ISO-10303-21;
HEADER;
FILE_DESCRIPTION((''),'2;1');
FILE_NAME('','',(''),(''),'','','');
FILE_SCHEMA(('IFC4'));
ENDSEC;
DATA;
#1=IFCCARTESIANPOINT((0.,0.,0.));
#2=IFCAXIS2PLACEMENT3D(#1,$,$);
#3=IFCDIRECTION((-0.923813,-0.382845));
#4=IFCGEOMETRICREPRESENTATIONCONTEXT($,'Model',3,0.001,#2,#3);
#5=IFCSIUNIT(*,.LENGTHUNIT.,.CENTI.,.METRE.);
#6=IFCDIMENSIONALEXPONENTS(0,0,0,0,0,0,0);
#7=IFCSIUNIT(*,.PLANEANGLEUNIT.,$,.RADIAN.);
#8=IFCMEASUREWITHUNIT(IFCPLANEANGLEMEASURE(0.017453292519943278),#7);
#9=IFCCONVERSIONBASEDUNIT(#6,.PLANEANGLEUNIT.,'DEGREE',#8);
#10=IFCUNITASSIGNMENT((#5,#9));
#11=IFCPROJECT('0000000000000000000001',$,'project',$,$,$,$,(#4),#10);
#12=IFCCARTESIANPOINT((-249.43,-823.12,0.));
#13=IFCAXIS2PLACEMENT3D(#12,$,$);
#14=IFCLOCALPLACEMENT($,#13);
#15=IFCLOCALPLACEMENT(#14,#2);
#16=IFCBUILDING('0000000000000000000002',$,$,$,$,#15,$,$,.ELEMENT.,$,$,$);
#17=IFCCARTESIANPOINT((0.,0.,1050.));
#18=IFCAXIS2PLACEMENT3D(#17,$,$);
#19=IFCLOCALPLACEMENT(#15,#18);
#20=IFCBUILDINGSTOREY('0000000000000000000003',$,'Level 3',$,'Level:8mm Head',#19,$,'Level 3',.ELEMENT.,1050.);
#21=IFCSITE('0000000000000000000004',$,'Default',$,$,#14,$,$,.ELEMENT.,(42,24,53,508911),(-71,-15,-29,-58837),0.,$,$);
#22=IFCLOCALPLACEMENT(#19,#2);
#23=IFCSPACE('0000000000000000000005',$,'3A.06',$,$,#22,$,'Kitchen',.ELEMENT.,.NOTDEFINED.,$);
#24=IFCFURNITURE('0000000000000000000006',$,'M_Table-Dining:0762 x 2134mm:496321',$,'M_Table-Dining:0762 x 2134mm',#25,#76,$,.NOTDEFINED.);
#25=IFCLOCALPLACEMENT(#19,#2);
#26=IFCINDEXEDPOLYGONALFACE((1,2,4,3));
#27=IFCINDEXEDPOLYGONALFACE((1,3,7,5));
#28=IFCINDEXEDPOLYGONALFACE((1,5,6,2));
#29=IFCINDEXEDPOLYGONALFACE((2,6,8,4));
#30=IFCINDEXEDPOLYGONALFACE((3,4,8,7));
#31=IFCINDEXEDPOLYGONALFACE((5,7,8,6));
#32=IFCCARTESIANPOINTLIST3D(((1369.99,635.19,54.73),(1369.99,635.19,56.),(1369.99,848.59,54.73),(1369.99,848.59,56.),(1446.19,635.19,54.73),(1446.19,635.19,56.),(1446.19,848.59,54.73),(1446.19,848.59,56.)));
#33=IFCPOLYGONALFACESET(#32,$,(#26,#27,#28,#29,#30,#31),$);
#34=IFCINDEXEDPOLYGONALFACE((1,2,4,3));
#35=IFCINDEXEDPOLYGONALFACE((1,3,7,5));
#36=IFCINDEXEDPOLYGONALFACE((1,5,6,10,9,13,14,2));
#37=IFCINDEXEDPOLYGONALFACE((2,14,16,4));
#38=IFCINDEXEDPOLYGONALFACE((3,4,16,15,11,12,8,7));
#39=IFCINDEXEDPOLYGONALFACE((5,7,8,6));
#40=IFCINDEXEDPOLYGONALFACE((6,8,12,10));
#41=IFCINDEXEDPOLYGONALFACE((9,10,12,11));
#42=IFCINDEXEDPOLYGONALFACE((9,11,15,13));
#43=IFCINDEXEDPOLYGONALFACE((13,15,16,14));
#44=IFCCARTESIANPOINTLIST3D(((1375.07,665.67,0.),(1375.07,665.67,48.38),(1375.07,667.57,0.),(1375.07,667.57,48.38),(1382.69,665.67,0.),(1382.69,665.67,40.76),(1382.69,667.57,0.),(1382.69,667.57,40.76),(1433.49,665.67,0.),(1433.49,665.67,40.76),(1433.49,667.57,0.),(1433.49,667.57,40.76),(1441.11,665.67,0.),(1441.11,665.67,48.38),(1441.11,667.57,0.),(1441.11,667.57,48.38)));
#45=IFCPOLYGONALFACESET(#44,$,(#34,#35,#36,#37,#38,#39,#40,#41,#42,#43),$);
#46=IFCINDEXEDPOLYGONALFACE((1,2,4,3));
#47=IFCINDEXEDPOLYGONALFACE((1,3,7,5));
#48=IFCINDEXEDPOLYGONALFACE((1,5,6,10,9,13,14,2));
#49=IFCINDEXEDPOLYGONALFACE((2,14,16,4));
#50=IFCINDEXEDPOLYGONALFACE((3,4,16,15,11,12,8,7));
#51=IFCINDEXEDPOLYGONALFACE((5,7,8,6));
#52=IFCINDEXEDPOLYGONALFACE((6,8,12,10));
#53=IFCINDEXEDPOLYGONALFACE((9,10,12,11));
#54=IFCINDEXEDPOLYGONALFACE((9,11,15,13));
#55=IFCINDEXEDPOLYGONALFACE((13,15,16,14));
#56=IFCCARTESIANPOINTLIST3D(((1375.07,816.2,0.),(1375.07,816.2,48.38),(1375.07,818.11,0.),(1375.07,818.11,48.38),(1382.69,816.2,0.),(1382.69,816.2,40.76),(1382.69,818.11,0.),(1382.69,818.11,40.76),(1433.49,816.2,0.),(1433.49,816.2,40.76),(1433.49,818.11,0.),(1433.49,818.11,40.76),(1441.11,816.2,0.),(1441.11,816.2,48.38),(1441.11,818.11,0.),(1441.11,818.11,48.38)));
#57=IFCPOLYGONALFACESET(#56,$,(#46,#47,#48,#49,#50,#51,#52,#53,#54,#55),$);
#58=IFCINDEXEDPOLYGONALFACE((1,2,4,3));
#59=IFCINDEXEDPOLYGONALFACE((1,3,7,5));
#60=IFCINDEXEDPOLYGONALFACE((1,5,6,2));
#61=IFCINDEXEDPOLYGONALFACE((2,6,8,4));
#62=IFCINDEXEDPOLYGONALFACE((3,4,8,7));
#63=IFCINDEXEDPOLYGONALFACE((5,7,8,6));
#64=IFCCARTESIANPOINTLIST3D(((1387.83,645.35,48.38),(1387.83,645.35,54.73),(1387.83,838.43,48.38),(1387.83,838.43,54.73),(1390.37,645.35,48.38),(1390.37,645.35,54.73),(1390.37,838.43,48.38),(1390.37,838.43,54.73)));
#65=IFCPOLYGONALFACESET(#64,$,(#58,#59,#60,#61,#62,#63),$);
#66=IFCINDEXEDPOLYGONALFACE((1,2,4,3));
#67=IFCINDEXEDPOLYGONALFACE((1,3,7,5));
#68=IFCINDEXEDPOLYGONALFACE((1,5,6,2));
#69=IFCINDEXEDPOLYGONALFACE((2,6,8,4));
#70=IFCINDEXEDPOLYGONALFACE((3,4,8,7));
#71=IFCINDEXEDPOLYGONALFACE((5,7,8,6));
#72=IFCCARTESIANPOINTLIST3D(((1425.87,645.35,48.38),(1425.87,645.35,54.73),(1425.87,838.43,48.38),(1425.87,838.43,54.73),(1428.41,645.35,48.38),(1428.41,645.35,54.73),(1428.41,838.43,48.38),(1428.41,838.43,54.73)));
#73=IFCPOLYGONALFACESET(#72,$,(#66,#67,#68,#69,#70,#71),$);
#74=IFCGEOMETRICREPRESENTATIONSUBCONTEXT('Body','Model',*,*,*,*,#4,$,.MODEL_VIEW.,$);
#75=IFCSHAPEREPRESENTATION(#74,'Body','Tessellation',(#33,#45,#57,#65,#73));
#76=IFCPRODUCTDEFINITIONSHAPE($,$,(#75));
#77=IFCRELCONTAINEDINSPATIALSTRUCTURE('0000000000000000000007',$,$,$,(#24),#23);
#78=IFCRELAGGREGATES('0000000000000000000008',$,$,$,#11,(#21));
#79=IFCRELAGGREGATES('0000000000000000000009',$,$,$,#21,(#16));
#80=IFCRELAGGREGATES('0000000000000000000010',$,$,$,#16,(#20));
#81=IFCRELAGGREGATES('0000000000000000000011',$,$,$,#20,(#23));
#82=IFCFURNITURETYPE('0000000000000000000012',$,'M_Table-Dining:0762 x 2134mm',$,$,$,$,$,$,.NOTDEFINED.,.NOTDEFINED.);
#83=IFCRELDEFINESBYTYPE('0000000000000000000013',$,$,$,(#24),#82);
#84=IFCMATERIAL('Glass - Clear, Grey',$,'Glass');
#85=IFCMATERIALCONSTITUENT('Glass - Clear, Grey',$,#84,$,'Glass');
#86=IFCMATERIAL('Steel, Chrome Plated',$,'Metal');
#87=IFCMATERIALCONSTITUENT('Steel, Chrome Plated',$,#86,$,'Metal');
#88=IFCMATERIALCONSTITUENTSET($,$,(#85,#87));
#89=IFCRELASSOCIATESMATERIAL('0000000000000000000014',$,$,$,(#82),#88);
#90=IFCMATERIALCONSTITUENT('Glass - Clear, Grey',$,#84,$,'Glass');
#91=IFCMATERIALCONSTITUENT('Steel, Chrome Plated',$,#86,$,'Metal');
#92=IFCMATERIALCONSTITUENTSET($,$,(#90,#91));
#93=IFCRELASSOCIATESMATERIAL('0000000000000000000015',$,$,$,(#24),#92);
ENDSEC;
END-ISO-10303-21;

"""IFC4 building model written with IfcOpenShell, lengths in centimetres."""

from ifc_helpers import new_model, entity, si_unit, converted_unit, direction, frame, origin, place, context, subcontext, project, spatial, indexed_curve, outline, extrude, source, transform, mapped, material, constituent, constituent_set, type_object, type_shapes, element, save


model = new_model("IFC4")

# Units and contexts
model_context = context("Model", 3, precision=0.001, world=origin(), true_north=direction((-0.923813, -0.382845)))
body_context = subcontext(model_context, "Body", "Model", "MODEL_VIEW")
ifc_project = project(units=[si_unit("LENGTHUNIT", "METRE", prefix="CENTI"), converted_unit("PLANEANGLEUNIT", "DEGREE", entity("IfcPlaneAngleMeasure", 0.017453292519943278), si_unit("PLANEANGLEUNIT", "RADIAN"), dimensions=[0, 0, 0, 0, 0, 0, 0])], contexts=[model_context])

# Site, building, storey
site_placement = place(None, frame((-249.43, -823.12, 0.0)))
site = spatial("IfcSite", under=ifc_project, at=site_placement, Name="Default", CompositionType="ELEMENT", RefLatitude=(42, 24, 53, 508911), RefLongitude=(-71, -15, -29, -58837), RefElevation=0.0)
building_placement = place(site_placement, origin())
building = spatial("IfcBuilding", under=site, at=building_placement, CompositionType="ELEMENT")
storey_placement = place(building_placement, frame((0.0, 0.0, 1050.0)))
storey = spatial("IfcBuildingStorey", under=building, at=storey_placement, Name="Level 3", ObjectType="Level:8mm Head", LongName="Level 3", CompositionType="ELEMENT", Elevation=1050.0)

# Shared definitions
space_1_placement = place(storey_placement, origin())
space_1 = spatial("IfcSpace", under=storey, at=space_1_placement, Name="3A.06", LongName="Kitchen", CompositionType="ELEMENT", PredefinedType="NOTDEFINED")

# Furniture
ifc_material_1 = material(Name="Glass - Clear, Grey", Category="Glass")
ifc_constituent_1 = constituent(ifc_material_1, Name="Glass - Clear, Grey", Category="Glass")
ifc_material_2 = material(Name="Steel, Chrome Plated", Category="Metal")
ifc_constituent_2 = constituent(ifc_material_2, Name="Steel, Chrome Plated", Category="Metal")
ifc_constituent_set_1 = constituent_set(constituents=[ifc_constituent_1, ifc_constituent_2])
ifc_constituent_3 = constituent(ifc_material_1, Name="Glass - Clear, Grey", Category="Glass")
ifc_constituent_4 = constituent(ifc_material_2, Name="Steel, Chrome Plated", Category="Metal")
ifc_constituent_set_2 = constituent_set(constituents=[ifc_constituent_3, ifc_constituent_4])
furniture_type_1 = type_object("IfcFurnitureType", Name="M_Table-Dining:0762 x 2134mm", AssemblyPlace="NOTDEFINED", PredefinedType="NOTDEFINED", material=ifc_constituent_set_2)
shared_shape_1 = source(origin(), body_context, "Body", "SweptSolid", [
    extrude(outline(indexed_curve([(-106.7, -38.1), (106.7, -38.1), (106.7, 38.1), (-106.7, 38.1), (-106.7, -38.1)], self_intersect=False)), frame((1.83, 9.52, 54.73), z_axis=(0.0, 0.0, 1.0), x_axis=(-1.0, 0.0, 0.0)), (0.0, 0.0, 1.0), 1.27),
    extrude(outline(indexed_curve([(-33.02, -26.09), (33.02, -26.09), (33.02, 22.28), (25.4, 22.28), (25.4, -18.47), (-25.4, -18.47), (-25.4, 22.28), (-33.02, 22.28), (-33.02, -26.09)], self_intersect=False)), frame((-74.39, 9.52, 22.28), z_axis=(1.0, 0.0, 0.0), x_axis=(0.0, -1.0, 0.0)), (0.0, 0.0, 1.0), 1.91),
    extrude(outline(indexed_curve([(-22.28, -33.02), (26.09, -33.02), (26.09, 33.02), (-22.28, 33.02), (-22.28, 25.4), (18.47, 25.4), (18.47, -25.4), (-22.28, -25.4), (-22.28, -33.02)], self_intersect=False)), frame((76.14, 9.52, 22.28), z_axis=(1.0, 0.0, 0.0), x_axis=(0.0, 0.0, 1.0)), (0.0, 0.0, 1.0), 1.91),
    extrude(outline(indexed_curve([(-96.54, -1.27), (96.54, -1.27), (96.54, 1.27), (-96.54, 1.27), (-96.54, -1.27)], self_intersect=False)), frame((1.83, 28.51, 48.38), z_axis=(0.0, 0.0, 1.0), x_axis=(-1.0, 0.0, 0.0)), (0.0, 0.0, 1.0), 6.35),
    extrude(outline(indexed_curve([(-96.54, -1.27), (96.54, -1.27), (96.54, 1.27), (-96.54, 1.27), (-96.54, -1.27)], self_intersect=False)), frame((1.83, -9.53, 48.38), z_axis=(0.0, 0.0, 1.0), x_axis=(-1.0, 0.0, 0.0)), (0.0, 0.0, 1.0), 6.35),
])
type_shapes(furniture_type_1, [shared_shape_1])
furniture_1_placement = place(space_1_placement, frame((1417.61, 740.06, 0.0), z_axis=(0.0, 0.0, 1.0), x_axis=(0.0, 1.0, 0.0)))
element("IfcFurniture", 1, at=furniture_1_placement, inside=space_1, type_object=furniture_type_1, material=ifc_constituent_set_1, Name="M_Table-Dining:0762 x 2134mm:496321", ObjectType="M_Table-Dining:0762 x 2134mm", PredefinedType="NOTDEFINED", context=body_context, shape_type="MappedRepresentation", body=[
    mapped(shared_shape_1, transform((0.0, 0.0, 0.0), scale=1.0)),
])

save(model, "model.ifc")
